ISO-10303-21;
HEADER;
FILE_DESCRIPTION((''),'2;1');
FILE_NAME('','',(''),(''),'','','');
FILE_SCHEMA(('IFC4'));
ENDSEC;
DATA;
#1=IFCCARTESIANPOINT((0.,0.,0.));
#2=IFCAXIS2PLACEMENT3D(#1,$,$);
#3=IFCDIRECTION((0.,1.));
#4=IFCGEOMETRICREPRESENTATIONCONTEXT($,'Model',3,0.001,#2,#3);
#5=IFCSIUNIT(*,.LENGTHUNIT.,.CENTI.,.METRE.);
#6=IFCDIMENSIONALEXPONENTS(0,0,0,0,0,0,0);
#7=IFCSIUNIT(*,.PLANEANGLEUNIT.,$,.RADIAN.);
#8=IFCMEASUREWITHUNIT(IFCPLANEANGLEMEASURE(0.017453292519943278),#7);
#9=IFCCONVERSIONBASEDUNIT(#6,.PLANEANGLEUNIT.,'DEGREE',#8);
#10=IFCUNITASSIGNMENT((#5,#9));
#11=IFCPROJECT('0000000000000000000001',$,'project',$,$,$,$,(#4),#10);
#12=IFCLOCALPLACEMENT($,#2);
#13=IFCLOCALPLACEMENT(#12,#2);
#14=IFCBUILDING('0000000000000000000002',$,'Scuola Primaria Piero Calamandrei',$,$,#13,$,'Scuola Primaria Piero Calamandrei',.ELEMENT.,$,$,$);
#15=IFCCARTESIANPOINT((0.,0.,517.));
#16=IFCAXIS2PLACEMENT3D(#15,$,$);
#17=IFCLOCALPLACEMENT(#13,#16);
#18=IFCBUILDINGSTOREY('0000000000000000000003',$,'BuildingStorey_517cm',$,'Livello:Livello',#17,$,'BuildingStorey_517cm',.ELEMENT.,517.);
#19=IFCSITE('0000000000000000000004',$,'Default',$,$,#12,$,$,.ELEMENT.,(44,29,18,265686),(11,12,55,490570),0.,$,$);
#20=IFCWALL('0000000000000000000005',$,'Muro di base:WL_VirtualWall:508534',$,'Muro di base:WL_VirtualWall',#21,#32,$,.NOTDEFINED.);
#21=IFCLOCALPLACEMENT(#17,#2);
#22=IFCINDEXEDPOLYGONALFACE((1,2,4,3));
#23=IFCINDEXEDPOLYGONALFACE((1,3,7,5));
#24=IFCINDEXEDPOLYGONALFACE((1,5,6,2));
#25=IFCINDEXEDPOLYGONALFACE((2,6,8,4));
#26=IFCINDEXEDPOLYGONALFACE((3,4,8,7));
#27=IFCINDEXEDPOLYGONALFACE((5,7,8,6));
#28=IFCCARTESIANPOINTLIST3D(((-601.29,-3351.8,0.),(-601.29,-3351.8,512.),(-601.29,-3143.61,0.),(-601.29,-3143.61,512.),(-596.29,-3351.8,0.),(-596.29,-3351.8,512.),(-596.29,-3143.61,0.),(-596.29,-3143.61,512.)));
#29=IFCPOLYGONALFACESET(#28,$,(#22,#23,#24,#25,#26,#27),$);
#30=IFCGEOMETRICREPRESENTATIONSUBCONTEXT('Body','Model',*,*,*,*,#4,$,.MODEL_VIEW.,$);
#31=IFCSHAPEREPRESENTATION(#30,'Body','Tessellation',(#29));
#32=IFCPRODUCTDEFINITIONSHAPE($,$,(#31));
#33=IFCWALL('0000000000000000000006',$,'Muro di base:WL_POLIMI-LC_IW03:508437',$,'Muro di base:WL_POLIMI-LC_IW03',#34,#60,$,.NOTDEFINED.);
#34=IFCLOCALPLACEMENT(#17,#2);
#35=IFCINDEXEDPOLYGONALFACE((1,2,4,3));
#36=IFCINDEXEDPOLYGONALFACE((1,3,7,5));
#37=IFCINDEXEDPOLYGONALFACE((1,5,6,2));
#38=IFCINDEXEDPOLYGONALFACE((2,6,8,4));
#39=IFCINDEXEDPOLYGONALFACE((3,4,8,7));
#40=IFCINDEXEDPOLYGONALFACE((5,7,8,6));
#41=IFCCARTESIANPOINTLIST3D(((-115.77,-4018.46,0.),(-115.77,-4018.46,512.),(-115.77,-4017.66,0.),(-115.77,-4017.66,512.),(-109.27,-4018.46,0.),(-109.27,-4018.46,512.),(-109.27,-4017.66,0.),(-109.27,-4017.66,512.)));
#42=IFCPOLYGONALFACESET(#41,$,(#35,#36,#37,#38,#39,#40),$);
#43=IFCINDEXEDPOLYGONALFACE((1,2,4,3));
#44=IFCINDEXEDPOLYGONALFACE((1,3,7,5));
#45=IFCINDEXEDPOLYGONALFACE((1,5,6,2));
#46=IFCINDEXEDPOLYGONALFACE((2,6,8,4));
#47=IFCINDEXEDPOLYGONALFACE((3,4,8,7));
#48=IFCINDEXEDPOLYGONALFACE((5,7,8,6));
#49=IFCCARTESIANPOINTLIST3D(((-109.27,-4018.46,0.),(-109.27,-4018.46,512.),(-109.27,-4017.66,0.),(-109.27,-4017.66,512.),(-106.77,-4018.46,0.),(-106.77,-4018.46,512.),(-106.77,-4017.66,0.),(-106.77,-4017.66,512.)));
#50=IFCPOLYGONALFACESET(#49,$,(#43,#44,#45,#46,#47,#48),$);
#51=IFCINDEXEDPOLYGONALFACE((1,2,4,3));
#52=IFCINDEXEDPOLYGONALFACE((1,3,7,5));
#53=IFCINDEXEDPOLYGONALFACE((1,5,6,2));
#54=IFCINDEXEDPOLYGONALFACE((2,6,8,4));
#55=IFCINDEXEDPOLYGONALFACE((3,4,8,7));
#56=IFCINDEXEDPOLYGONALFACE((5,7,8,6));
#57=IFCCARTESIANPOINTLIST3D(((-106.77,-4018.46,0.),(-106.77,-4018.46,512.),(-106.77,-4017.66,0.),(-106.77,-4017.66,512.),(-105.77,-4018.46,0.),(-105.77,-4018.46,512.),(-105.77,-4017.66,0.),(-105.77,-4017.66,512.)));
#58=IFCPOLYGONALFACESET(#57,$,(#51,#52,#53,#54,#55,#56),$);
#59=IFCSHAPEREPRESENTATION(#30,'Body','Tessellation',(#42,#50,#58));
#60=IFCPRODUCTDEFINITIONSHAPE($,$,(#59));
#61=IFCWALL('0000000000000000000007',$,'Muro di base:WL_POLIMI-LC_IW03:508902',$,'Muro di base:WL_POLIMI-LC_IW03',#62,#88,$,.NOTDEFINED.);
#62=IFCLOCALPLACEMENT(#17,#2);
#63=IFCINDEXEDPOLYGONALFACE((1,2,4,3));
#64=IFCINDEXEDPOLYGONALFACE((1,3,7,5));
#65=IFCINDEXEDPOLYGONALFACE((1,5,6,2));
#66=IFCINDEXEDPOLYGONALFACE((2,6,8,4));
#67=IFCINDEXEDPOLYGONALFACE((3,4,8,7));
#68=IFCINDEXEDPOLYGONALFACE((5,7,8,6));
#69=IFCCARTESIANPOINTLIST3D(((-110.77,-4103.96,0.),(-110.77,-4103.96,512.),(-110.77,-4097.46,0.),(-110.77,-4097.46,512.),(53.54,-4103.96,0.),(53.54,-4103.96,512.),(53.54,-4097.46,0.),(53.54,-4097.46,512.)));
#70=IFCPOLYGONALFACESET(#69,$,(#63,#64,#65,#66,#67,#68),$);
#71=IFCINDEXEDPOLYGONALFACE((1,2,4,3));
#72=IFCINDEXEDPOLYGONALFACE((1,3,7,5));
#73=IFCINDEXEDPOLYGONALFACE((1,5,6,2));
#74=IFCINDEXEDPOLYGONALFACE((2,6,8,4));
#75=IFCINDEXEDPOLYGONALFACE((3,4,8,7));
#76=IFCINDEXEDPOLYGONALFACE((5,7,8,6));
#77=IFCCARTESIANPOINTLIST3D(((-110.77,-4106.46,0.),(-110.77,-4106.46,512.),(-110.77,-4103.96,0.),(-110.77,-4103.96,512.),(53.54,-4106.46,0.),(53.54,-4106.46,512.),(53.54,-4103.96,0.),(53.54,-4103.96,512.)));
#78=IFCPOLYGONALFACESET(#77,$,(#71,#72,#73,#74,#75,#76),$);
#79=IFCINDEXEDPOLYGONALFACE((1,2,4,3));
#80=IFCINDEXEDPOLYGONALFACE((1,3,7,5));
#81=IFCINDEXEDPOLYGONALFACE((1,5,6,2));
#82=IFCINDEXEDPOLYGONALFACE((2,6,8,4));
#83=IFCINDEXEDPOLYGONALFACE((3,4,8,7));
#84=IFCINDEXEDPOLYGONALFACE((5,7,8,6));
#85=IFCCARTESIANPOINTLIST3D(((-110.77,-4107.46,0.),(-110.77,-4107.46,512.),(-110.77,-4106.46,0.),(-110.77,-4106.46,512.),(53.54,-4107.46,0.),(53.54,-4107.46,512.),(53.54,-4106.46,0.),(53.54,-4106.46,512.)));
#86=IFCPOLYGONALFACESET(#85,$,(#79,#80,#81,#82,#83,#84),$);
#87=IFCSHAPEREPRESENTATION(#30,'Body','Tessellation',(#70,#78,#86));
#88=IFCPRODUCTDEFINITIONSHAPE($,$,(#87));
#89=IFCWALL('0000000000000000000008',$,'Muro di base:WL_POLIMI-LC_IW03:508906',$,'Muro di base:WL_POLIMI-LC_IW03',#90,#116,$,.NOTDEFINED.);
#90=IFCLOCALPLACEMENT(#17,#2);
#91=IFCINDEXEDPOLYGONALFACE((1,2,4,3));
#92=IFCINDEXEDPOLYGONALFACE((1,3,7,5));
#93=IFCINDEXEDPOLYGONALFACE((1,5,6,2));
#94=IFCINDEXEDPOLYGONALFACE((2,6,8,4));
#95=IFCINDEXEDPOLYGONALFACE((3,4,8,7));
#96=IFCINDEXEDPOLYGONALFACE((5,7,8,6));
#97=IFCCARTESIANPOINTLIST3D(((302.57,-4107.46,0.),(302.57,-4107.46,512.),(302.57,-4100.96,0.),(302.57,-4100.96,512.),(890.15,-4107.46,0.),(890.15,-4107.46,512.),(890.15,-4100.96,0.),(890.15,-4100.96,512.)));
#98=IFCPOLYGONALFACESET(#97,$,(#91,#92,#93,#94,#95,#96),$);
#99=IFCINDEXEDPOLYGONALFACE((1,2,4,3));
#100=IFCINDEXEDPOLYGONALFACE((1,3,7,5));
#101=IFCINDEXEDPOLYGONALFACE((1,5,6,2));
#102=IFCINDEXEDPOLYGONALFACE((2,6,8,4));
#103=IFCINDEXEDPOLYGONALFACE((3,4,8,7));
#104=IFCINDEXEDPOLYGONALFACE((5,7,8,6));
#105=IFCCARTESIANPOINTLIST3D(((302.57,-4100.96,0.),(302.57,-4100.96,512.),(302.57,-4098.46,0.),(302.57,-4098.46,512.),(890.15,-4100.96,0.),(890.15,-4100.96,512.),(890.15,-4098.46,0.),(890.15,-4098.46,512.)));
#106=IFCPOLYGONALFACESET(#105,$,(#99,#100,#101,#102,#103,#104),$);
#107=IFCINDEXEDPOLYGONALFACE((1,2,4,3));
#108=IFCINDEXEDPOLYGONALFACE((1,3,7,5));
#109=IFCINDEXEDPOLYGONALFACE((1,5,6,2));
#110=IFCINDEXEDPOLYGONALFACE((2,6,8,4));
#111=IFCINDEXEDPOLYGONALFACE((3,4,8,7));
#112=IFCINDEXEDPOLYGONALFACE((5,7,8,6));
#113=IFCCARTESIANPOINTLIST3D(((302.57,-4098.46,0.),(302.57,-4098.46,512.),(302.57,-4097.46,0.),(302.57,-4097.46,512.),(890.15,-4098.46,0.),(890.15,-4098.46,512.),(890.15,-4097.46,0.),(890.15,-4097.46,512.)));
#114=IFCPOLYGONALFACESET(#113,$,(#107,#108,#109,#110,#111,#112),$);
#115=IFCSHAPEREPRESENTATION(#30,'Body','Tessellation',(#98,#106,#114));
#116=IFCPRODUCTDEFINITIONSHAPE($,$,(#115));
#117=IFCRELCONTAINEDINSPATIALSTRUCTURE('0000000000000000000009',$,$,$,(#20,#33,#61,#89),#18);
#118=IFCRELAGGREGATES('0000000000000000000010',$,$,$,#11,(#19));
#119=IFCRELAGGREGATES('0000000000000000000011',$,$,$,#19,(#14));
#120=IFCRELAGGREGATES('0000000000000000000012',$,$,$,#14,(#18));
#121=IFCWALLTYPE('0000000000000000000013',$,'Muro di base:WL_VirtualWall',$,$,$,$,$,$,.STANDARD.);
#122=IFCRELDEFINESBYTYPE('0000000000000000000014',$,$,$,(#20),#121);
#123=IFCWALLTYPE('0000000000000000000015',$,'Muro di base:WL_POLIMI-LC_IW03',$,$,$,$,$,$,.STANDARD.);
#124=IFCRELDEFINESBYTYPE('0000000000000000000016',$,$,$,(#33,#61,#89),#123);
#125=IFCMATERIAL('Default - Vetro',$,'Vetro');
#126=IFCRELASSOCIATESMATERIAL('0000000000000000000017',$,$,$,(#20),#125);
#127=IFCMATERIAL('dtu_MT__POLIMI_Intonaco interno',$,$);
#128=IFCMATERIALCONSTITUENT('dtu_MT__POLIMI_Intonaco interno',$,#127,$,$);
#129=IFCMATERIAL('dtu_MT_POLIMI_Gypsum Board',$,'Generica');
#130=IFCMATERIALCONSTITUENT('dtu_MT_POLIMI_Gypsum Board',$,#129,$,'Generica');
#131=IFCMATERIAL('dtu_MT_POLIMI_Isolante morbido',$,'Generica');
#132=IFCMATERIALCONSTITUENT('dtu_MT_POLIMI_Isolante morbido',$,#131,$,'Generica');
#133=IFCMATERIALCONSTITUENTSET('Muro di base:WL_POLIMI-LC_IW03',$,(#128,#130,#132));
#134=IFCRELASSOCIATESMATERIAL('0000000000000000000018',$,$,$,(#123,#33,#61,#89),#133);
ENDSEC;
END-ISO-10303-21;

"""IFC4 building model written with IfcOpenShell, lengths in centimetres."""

from ifc_helpers import new_model, entity, si_unit, converted_unit, direction, frame, origin, place, context, subcontext, project, spatial, indexed_curve, outline, extrude, material, constituent, constituent_set, type_object, element, save


model = new_model("IFC4")

# Units and contexts
model_context = context("Model", 3, precision=0.001, world=origin(), true_north=direction((0.0, 1.0)))
body_context = subcontext(model_context, "Body", "Model", "MODEL_VIEW")
ifc_project = project(units=[si_unit("LENGTHUNIT", "METRE", prefix="CENTI"), converted_unit("PLANEANGLEUNIT", "DEGREE", entity("IfcPlaneAngleMeasure", 0.017453292519943278), si_unit("PLANEANGLEUNIT", "RADIAN"), dimensions=[0, 0, 0, 0, 0, 0, 0])], contexts=[model_context])

# Site, building, storey
site_placement = place(None, origin())
site = spatial("IfcSite", under=ifc_project, at=site_placement, Name="Default", CompositionType="ELEMENT", RefLatitude=(44, 29, 18, 265686), RefLongitude=(11, 12, 55, 490570), RefElevation=0.0)
building_placement = place(site_placement, origin())
building = spatial("IfcBuilding", under=site, at=building_placement, Name="Scuola Primaria Piero Calamandrei", LongName="Scuola Primaria Piero Calamandrei", CompositionType="ELEMENT")
storey_placement = place(building_placement, frame((0.0, 0.0, 517.0)))
storey = spatial("IfcBuildingStorey", under=building, at=storey_placement, Name="BuildingStorey_517cm", ObjectType="Livello:Livello", LongName="BuildingStorey_517cm", CompositionType="ELEMENT", Elevation=517.0)

# Shared definitions
ifc_material_1 = material(Name="dtu_MT__POLIMI_Intonaco interno")
ifc_material_2 = material(Name="dtu_MT_POLIMI_Isolante morbido", Category="Generica")
ifc_material_3 = material(Name="dtu_MT_POLIMI_Gypsum Board", Category="Generica")

# Wall
ifc_material_4 = material(Name="Default - Vetro", Category="Vetro")
wall_type_1 = type_object("IfcWallType", Name="Muro di base:WL_VirtualWall", PredefinedType="STANDARD")
wall_1_placement = place(storey_placement, frame((-598.79, -3351.8, 0.0), z_axis=(0.0, 0.0, 1.0), x_axis=(0.0, 1.0, 0.0)))
element("IfcWall", 1, at=wall_1_placement, inside=storey, type_object=wall_type_1, material=ifc_material_4, Name="Muro di base:WL_VirtualWall:508534", ObjectType="Muro di base:WL_VirtualWall", PredefinedType="NOTDEFINED", context=body_context, shape_type="SweptSolid", body=[
    extrude(outline(indexed_curve([(208.19, 2.5), (0.0, 2.5), (0.0, -2.5), (208.19, -2.5), (208.19, 2.5)], self_intersect=False)), origin(), (0.0, 0.0, 1.0), 512.0),
])

# Walls
ifc_constituent_1 = constituent(ifc_material_1, Name="dtu_MT__POLIMI_Intonaco interno")
ifc_constituent_2 = constituent(ifc_material_3, Name="dtu_MT_POLIMI_Gypsum Board", Category="Generica")
ifc_constituent_3 = constituent(ifc_material_2, Name="dtu_MT_POLIMI_Isolante morbido", Category="Generica")
ifc_constituent_set_1 = constituent_set(constituents=[ifc_constituent_1, ifc_constituent_2, ifc_constituent_3], Name="Muro di base:WL_POLIMI-LC_IW03")
wall_type_2 = type_object("IfcWallType", Name="Muro di base:WL_POLIMI-LC_IW03", PredefinedType="STANDARD", material=ifc_constituent_set_1)
wall_2_placement = place(storey_placement, frame((-110.77, -4017.66, 0.0), z_axis=(0.0, 0.0, 1.0), x_axis=(0.0, -1.0, 0.0)))
element("IfcWall", 2, at=wall_2_placement, inside=storey, type_object=wall_type_2, material=ifc_constituent_set_1, Name="Muro di base:WL_POLIMI-LC_IW03:508437", ObjectType="Muro di base:WL_POLIMI-LC_IW03", PredefinedType="NOTDEFINED", context=body_context, shape_type="SweptSolid", body=[
    extrude(outline(indexed_curve([(-3.25, -0.4), (3.25, -0.4), (3.25, 0.4), (-3.25, 0.4), (-3.25, -0.4)], self_intersect=False)), frame((0.4, -1.75, 0.0), z_axis=(0.0, 0.0, 1.0), x_axis=(0.0, 1.0, 0.0)), (0.0, 0.0, 1.0), 512.0),
    extrude(outline(indexed_curve([(-0.4, -1.25), (0.4, -1.25), (0.4, 1.25), (-0.4, 1.25), (-0.4, -1.25)], self_intersect=False)), frame((0.4, 2.75, 0.0)), (0.0, 0.0, 1.0), 512.0),
    extrude(outline(indexed_curve([(-0.5, -0.4), (0.5, -0.4), (0.5, 0.4), (-0.5, 0.4), (-0.5, -0.4)], self_intersect=False)), frame((0.4, 4.5, 0.0), z_axis=(0.0, 0.0, 1.0), x_axis=(0.0, -1.0, 0.0)), (0.0, 0.0, 1.0), 512.0),
])
wall_3_placement = place(storey_placement, frame((53.54, -4102.46, 0.0), z_axis=(0.0, 0.0, 1.0), x_axis=(-1.0, 0.0, 0.0)))
element("IfcWall", 3, at=wall_3_placement, inside=storey, type_object=wall_type_2, material=ifc_constituent_set_1, Name="Muro di base:WL_POLIMI-LC_IW03:508902", ObjectType="Muro di base:WL_POLIMI-LC_IW03", PredefinedType="NOTDEFINED", context=body_context, shape_type="SweptSolid", body=[
    extrude(outline(indexed_curve([(-3.25, -82.16), (3.25, -82.16), (3.25, 82.16), (-3.25, 82.16), (-3.25, -82.16)], self_intersect=False)), frame((82.16, -1.75, 0.0), z_axis=(0.0, 0.0, 1.0), x_axis=(0.0, 1.0, 0.0)), (0.0, 0.0, 1.0), 512.0),
    extrude(outline(indexed_curve([(-82.16, -1.25), (82.16, -1.25), (82.16, 1.25), (-82.16, 1.25), (-82.16, -1.25)], self_intersect=False)), frame((82.16, 2.75, 0.0)), (0.0, 0.0, 1.0), 512.0),
    extrude(outline(indexed_curve([(-0.5, -82.16), (0.5, -82.16), (0.5, 82.16), (-0.5, 82.16), (-0.5, -82.16)], self_intersect=False)), frame((82.16, 4.5, 0.0), z_axis=(0.0, 0.0, 1.0), x_axis=(0.0, -1.0, 0.0)), (0.0, 0.0, 1.0), 512.0),
])
wall_4_placement = place(storey_placement, frame((302.57, -4102.46, 0.0)))
element("IfcWall", 4, at=wall_4_placement, inside=storey, type_object=wall_type_2, material=ifc_constituent_set_1, Name="Muro di base:WL_POLIMI-LC_IW03:508906", ObjectType="Muro di base:WL_POLIMI-LC_IW03", PredefinedType="NOTDEFINED", context=body_context, shape_type="SweptSolid", body=[
    extrude(outline(indexed_curve([(-3.25, -293.79), (3.25, -293.79), (3.25, 293.79), (-3.25, 293.79), (-3.25, -293.79)], self_intersect=False)), frame((293.79, -1.75, 0.0), z_axis=(0.0, 0.0, 1.0), x_axis=(0.0, 1.0, 0.0)), (0.0, 0.0, 1.0), 512.0),
    extrude(outline(indexed_curve([(-293.79, -1.25), (293.79, -1.25), (293.79, 1.25), (-293.79, 1.25), (-293.79, -1.25)], self_intersect=False)), frame((293.79, 2.75, 0.0)), (0.0, 0.0, 1.0), 512.0),
    extrude(outline(indexed_curve([(-0.5, -293.79), (0.5, -293.79), (0.5, 293.79), (-0.5, 293.79), (-0.5, -293.79)], self_intersect=False)), frame((293.79, 4.5, 0.0), z_axis=(0.0, 0.0, 1.0), x_axis=(0.0, -1.0, 0.0)), (0.0, 0.0, 1.0), 512.0),
])

save(model, "model.ifc")
